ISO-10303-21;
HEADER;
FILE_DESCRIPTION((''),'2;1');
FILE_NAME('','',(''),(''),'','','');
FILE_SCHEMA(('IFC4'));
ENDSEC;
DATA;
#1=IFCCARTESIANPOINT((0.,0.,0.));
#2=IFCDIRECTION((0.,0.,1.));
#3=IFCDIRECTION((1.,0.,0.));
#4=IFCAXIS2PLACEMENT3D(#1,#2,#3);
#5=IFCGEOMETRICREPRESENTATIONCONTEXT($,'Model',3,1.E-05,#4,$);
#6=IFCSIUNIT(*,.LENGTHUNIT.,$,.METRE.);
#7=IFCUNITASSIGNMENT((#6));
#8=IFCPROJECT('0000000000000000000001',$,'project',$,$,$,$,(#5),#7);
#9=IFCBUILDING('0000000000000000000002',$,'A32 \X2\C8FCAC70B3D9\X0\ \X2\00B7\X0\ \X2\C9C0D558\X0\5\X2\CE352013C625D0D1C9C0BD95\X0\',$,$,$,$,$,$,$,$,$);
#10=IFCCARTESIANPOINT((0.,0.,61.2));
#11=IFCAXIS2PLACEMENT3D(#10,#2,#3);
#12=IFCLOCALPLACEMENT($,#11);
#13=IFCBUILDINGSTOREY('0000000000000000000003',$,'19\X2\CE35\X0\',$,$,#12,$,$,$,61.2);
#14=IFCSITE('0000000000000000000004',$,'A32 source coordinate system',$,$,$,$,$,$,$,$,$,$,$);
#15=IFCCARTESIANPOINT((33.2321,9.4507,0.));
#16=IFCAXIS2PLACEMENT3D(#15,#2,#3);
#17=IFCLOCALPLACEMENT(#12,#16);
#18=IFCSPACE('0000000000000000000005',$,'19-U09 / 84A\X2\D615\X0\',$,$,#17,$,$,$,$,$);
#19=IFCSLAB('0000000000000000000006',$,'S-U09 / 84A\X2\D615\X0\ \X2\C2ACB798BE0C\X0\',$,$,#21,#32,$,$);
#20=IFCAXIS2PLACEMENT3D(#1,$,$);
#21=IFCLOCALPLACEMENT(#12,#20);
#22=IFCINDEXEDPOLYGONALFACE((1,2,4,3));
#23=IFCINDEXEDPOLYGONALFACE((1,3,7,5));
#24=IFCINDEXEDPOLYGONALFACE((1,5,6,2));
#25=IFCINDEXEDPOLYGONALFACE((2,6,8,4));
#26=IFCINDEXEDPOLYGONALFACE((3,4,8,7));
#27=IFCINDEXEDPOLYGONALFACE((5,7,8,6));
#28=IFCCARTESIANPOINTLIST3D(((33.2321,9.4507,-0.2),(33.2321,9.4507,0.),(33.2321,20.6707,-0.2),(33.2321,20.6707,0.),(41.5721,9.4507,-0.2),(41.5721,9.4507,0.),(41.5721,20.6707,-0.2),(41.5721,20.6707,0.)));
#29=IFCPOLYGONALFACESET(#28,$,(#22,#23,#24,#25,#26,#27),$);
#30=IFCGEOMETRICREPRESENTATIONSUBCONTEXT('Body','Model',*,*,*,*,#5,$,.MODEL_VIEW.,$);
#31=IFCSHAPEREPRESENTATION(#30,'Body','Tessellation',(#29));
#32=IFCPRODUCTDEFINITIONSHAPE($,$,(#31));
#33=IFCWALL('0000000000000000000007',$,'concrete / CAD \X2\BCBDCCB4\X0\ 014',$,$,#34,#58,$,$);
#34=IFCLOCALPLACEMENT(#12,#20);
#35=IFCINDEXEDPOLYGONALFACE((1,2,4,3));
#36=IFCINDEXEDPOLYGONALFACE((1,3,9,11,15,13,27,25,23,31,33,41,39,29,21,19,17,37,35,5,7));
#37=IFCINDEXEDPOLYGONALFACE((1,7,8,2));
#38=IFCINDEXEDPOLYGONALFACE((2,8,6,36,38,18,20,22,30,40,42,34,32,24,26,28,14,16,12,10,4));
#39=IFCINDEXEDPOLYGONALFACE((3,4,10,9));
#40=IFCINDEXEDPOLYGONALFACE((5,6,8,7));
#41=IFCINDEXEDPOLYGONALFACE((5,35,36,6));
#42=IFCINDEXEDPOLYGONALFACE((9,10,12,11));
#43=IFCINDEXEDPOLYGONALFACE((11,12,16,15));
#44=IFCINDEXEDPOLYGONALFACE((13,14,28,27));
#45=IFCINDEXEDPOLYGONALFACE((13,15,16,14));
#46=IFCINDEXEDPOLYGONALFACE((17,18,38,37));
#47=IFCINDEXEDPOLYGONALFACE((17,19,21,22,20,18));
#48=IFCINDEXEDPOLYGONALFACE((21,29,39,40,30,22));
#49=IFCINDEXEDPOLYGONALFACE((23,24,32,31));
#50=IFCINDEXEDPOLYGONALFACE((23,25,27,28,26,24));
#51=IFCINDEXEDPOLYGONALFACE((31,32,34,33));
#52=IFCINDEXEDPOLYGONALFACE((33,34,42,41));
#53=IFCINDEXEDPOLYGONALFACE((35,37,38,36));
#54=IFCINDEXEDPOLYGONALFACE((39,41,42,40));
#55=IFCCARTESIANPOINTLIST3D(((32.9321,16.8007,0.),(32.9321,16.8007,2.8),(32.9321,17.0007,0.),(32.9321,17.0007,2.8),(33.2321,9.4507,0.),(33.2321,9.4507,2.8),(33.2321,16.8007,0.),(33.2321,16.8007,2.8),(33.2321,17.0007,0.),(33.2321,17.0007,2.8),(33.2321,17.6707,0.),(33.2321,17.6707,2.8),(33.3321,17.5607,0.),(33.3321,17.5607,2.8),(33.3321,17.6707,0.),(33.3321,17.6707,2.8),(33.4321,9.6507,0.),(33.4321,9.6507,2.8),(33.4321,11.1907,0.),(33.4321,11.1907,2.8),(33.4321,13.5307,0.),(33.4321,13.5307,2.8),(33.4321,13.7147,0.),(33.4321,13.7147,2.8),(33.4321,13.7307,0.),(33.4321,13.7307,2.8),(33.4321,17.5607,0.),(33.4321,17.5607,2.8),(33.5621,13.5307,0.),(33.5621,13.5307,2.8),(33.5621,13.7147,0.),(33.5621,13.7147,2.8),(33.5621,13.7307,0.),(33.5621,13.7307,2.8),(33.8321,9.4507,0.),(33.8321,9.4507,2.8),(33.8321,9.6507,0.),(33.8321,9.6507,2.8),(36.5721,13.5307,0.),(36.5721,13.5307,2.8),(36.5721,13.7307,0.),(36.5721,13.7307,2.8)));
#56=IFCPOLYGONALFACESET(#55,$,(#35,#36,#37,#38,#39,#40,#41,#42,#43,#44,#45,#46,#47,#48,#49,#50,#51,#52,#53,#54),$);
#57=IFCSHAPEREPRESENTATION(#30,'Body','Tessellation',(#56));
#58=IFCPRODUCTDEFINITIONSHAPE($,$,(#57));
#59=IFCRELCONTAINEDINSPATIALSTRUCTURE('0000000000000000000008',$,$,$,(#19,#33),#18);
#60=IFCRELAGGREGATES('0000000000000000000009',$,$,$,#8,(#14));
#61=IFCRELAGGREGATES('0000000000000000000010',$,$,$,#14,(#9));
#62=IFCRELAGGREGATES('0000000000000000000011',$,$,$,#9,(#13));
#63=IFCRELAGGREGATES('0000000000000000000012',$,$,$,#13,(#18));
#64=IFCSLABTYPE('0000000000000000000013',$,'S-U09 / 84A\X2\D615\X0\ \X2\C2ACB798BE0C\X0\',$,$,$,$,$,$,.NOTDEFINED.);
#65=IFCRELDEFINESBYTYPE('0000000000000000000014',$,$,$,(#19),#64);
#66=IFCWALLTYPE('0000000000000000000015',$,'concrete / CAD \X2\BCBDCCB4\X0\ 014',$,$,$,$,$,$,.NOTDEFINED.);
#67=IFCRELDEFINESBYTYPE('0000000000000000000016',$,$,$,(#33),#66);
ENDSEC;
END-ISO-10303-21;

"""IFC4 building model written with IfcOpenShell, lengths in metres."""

from ifc_helpers import new_model, si_unit, frame, origin, origin_with_axes, place, context, subcontext, project, spatial, polyline, outline, extrude, source, transform, mapped, type_object, type_shapes, element, save


model = new_model("IFC4")

# Units and contexts
model_context = context("Model", 3, precision=1e-05, world=origin_with_axes())
body_context = subcontext(model_context, "Body", "Model", "MODEL_VIEW")
ifc_project = project(units=[si_unit("LENGTHUNIT", "METRE")], contexts=[model_context])

# Site, building, storey, space
storey_placement = place(None, frame((0.0, 0.0, 61.2), z_axis=(0.0, 0.0, 1.0), x_axis=(1.0, 0.0, 0.0)))
space_placement = place(storey_placement, frame((33.2321, 9.4507, 0.0), z_axis=(0.0, 0.0, 1.0), x_axis=(1.0, 0.0, 0.0)))
site = spatial("IfcSite", under=ifc_project, Name="A32 source coordinate system")
building = spatial("IfcBuilding", under=site, Name="A32 주거동 · 지하5층–옥탑지붕")
storey = spatial("IfcBuildingStorey", under=building, at=storey_placement, Name="19층", Elevation=61.2)
space = spatial("IfcSpace", under=storey, at=space_placement, Name="19-U09 / 84A형")

# Slab
slab_type_1 = type_object("IfcSlabType", Name="S-U09 / 84A형 슬래브", PredefinedType="NOTDEFINED")
shared_shape_1 = source(origin(), body_context, "Body", "SweptSolid", [
    extrude(outline(polyline([(0.0, 11.22), (8.34, 11.22), (8.34, 0.0), (0.0, 0.0), (0.0, 11.22)])), frame((0.0, 0.0, -0.2)), (0.0, 0.0, 1.0), 0.2),
])
type_shapes(slab_type_1, [shared_shape_1])
slab_1_placement = place(space_placement, origin_with_axes())
element("IfcSlab", 1, at=slab_1_placement, inside=space, type_object=slab_type_1, Name="S-U09 / 84A형 슬래브", context=body_context, shape_type="MappedRepresentation", body=[
    mapped(shared_shape_1, transform((0.0, 0.0, 0.0), scale=1.0)),
])

# Wall
wall_type_1 = type_object("IfcWallType", Name="concrete / CAD 벽체 014", PredefinedType="NOTDEFINED")
shared_shape_2 = source(origin(), body_context, "Body", "SweptSolid", [
    extrude(outline(polyline([(3.34, 4.08), (0.33, 4.08), (0.2, 4.08), (0.2, 1.74), (0.2, 0.2), (0.6, 0.2), (0.6, 0.0), (0.0, 0.0), (0.0, 7.35), (-0.3, 7.35), (-0.3, 7.55), (0.0, 7.55), (0.0, 8.22), (0.1, 8.22), (0.1, 8.11), (0.2, 8.11), (0.2, 4.28), (0.2, 4.264), (0.33, 4.264), (0.33, 4.28), (3.34, 4.28), (3.34, 4.08)])), origin(), (0.0, 0.0, 1.0), 2.8),
])
type_shapes(wall_type_1, [shared_shape_2])
wall_1_placement = place(space_placement, origin_with_axes())
element("IfcWall", 2, at=wall_1_placement, inside=space, type_object=wall_type_1, Name="concrete / CAD 벽체 014", context=body_context, shape_type="MappedRepresentation", body=[
    mapped(shared_shape_2, transform((0.0, 0.0, 0.0), scale=1.0)),
])

save(model, "model.ifc")
